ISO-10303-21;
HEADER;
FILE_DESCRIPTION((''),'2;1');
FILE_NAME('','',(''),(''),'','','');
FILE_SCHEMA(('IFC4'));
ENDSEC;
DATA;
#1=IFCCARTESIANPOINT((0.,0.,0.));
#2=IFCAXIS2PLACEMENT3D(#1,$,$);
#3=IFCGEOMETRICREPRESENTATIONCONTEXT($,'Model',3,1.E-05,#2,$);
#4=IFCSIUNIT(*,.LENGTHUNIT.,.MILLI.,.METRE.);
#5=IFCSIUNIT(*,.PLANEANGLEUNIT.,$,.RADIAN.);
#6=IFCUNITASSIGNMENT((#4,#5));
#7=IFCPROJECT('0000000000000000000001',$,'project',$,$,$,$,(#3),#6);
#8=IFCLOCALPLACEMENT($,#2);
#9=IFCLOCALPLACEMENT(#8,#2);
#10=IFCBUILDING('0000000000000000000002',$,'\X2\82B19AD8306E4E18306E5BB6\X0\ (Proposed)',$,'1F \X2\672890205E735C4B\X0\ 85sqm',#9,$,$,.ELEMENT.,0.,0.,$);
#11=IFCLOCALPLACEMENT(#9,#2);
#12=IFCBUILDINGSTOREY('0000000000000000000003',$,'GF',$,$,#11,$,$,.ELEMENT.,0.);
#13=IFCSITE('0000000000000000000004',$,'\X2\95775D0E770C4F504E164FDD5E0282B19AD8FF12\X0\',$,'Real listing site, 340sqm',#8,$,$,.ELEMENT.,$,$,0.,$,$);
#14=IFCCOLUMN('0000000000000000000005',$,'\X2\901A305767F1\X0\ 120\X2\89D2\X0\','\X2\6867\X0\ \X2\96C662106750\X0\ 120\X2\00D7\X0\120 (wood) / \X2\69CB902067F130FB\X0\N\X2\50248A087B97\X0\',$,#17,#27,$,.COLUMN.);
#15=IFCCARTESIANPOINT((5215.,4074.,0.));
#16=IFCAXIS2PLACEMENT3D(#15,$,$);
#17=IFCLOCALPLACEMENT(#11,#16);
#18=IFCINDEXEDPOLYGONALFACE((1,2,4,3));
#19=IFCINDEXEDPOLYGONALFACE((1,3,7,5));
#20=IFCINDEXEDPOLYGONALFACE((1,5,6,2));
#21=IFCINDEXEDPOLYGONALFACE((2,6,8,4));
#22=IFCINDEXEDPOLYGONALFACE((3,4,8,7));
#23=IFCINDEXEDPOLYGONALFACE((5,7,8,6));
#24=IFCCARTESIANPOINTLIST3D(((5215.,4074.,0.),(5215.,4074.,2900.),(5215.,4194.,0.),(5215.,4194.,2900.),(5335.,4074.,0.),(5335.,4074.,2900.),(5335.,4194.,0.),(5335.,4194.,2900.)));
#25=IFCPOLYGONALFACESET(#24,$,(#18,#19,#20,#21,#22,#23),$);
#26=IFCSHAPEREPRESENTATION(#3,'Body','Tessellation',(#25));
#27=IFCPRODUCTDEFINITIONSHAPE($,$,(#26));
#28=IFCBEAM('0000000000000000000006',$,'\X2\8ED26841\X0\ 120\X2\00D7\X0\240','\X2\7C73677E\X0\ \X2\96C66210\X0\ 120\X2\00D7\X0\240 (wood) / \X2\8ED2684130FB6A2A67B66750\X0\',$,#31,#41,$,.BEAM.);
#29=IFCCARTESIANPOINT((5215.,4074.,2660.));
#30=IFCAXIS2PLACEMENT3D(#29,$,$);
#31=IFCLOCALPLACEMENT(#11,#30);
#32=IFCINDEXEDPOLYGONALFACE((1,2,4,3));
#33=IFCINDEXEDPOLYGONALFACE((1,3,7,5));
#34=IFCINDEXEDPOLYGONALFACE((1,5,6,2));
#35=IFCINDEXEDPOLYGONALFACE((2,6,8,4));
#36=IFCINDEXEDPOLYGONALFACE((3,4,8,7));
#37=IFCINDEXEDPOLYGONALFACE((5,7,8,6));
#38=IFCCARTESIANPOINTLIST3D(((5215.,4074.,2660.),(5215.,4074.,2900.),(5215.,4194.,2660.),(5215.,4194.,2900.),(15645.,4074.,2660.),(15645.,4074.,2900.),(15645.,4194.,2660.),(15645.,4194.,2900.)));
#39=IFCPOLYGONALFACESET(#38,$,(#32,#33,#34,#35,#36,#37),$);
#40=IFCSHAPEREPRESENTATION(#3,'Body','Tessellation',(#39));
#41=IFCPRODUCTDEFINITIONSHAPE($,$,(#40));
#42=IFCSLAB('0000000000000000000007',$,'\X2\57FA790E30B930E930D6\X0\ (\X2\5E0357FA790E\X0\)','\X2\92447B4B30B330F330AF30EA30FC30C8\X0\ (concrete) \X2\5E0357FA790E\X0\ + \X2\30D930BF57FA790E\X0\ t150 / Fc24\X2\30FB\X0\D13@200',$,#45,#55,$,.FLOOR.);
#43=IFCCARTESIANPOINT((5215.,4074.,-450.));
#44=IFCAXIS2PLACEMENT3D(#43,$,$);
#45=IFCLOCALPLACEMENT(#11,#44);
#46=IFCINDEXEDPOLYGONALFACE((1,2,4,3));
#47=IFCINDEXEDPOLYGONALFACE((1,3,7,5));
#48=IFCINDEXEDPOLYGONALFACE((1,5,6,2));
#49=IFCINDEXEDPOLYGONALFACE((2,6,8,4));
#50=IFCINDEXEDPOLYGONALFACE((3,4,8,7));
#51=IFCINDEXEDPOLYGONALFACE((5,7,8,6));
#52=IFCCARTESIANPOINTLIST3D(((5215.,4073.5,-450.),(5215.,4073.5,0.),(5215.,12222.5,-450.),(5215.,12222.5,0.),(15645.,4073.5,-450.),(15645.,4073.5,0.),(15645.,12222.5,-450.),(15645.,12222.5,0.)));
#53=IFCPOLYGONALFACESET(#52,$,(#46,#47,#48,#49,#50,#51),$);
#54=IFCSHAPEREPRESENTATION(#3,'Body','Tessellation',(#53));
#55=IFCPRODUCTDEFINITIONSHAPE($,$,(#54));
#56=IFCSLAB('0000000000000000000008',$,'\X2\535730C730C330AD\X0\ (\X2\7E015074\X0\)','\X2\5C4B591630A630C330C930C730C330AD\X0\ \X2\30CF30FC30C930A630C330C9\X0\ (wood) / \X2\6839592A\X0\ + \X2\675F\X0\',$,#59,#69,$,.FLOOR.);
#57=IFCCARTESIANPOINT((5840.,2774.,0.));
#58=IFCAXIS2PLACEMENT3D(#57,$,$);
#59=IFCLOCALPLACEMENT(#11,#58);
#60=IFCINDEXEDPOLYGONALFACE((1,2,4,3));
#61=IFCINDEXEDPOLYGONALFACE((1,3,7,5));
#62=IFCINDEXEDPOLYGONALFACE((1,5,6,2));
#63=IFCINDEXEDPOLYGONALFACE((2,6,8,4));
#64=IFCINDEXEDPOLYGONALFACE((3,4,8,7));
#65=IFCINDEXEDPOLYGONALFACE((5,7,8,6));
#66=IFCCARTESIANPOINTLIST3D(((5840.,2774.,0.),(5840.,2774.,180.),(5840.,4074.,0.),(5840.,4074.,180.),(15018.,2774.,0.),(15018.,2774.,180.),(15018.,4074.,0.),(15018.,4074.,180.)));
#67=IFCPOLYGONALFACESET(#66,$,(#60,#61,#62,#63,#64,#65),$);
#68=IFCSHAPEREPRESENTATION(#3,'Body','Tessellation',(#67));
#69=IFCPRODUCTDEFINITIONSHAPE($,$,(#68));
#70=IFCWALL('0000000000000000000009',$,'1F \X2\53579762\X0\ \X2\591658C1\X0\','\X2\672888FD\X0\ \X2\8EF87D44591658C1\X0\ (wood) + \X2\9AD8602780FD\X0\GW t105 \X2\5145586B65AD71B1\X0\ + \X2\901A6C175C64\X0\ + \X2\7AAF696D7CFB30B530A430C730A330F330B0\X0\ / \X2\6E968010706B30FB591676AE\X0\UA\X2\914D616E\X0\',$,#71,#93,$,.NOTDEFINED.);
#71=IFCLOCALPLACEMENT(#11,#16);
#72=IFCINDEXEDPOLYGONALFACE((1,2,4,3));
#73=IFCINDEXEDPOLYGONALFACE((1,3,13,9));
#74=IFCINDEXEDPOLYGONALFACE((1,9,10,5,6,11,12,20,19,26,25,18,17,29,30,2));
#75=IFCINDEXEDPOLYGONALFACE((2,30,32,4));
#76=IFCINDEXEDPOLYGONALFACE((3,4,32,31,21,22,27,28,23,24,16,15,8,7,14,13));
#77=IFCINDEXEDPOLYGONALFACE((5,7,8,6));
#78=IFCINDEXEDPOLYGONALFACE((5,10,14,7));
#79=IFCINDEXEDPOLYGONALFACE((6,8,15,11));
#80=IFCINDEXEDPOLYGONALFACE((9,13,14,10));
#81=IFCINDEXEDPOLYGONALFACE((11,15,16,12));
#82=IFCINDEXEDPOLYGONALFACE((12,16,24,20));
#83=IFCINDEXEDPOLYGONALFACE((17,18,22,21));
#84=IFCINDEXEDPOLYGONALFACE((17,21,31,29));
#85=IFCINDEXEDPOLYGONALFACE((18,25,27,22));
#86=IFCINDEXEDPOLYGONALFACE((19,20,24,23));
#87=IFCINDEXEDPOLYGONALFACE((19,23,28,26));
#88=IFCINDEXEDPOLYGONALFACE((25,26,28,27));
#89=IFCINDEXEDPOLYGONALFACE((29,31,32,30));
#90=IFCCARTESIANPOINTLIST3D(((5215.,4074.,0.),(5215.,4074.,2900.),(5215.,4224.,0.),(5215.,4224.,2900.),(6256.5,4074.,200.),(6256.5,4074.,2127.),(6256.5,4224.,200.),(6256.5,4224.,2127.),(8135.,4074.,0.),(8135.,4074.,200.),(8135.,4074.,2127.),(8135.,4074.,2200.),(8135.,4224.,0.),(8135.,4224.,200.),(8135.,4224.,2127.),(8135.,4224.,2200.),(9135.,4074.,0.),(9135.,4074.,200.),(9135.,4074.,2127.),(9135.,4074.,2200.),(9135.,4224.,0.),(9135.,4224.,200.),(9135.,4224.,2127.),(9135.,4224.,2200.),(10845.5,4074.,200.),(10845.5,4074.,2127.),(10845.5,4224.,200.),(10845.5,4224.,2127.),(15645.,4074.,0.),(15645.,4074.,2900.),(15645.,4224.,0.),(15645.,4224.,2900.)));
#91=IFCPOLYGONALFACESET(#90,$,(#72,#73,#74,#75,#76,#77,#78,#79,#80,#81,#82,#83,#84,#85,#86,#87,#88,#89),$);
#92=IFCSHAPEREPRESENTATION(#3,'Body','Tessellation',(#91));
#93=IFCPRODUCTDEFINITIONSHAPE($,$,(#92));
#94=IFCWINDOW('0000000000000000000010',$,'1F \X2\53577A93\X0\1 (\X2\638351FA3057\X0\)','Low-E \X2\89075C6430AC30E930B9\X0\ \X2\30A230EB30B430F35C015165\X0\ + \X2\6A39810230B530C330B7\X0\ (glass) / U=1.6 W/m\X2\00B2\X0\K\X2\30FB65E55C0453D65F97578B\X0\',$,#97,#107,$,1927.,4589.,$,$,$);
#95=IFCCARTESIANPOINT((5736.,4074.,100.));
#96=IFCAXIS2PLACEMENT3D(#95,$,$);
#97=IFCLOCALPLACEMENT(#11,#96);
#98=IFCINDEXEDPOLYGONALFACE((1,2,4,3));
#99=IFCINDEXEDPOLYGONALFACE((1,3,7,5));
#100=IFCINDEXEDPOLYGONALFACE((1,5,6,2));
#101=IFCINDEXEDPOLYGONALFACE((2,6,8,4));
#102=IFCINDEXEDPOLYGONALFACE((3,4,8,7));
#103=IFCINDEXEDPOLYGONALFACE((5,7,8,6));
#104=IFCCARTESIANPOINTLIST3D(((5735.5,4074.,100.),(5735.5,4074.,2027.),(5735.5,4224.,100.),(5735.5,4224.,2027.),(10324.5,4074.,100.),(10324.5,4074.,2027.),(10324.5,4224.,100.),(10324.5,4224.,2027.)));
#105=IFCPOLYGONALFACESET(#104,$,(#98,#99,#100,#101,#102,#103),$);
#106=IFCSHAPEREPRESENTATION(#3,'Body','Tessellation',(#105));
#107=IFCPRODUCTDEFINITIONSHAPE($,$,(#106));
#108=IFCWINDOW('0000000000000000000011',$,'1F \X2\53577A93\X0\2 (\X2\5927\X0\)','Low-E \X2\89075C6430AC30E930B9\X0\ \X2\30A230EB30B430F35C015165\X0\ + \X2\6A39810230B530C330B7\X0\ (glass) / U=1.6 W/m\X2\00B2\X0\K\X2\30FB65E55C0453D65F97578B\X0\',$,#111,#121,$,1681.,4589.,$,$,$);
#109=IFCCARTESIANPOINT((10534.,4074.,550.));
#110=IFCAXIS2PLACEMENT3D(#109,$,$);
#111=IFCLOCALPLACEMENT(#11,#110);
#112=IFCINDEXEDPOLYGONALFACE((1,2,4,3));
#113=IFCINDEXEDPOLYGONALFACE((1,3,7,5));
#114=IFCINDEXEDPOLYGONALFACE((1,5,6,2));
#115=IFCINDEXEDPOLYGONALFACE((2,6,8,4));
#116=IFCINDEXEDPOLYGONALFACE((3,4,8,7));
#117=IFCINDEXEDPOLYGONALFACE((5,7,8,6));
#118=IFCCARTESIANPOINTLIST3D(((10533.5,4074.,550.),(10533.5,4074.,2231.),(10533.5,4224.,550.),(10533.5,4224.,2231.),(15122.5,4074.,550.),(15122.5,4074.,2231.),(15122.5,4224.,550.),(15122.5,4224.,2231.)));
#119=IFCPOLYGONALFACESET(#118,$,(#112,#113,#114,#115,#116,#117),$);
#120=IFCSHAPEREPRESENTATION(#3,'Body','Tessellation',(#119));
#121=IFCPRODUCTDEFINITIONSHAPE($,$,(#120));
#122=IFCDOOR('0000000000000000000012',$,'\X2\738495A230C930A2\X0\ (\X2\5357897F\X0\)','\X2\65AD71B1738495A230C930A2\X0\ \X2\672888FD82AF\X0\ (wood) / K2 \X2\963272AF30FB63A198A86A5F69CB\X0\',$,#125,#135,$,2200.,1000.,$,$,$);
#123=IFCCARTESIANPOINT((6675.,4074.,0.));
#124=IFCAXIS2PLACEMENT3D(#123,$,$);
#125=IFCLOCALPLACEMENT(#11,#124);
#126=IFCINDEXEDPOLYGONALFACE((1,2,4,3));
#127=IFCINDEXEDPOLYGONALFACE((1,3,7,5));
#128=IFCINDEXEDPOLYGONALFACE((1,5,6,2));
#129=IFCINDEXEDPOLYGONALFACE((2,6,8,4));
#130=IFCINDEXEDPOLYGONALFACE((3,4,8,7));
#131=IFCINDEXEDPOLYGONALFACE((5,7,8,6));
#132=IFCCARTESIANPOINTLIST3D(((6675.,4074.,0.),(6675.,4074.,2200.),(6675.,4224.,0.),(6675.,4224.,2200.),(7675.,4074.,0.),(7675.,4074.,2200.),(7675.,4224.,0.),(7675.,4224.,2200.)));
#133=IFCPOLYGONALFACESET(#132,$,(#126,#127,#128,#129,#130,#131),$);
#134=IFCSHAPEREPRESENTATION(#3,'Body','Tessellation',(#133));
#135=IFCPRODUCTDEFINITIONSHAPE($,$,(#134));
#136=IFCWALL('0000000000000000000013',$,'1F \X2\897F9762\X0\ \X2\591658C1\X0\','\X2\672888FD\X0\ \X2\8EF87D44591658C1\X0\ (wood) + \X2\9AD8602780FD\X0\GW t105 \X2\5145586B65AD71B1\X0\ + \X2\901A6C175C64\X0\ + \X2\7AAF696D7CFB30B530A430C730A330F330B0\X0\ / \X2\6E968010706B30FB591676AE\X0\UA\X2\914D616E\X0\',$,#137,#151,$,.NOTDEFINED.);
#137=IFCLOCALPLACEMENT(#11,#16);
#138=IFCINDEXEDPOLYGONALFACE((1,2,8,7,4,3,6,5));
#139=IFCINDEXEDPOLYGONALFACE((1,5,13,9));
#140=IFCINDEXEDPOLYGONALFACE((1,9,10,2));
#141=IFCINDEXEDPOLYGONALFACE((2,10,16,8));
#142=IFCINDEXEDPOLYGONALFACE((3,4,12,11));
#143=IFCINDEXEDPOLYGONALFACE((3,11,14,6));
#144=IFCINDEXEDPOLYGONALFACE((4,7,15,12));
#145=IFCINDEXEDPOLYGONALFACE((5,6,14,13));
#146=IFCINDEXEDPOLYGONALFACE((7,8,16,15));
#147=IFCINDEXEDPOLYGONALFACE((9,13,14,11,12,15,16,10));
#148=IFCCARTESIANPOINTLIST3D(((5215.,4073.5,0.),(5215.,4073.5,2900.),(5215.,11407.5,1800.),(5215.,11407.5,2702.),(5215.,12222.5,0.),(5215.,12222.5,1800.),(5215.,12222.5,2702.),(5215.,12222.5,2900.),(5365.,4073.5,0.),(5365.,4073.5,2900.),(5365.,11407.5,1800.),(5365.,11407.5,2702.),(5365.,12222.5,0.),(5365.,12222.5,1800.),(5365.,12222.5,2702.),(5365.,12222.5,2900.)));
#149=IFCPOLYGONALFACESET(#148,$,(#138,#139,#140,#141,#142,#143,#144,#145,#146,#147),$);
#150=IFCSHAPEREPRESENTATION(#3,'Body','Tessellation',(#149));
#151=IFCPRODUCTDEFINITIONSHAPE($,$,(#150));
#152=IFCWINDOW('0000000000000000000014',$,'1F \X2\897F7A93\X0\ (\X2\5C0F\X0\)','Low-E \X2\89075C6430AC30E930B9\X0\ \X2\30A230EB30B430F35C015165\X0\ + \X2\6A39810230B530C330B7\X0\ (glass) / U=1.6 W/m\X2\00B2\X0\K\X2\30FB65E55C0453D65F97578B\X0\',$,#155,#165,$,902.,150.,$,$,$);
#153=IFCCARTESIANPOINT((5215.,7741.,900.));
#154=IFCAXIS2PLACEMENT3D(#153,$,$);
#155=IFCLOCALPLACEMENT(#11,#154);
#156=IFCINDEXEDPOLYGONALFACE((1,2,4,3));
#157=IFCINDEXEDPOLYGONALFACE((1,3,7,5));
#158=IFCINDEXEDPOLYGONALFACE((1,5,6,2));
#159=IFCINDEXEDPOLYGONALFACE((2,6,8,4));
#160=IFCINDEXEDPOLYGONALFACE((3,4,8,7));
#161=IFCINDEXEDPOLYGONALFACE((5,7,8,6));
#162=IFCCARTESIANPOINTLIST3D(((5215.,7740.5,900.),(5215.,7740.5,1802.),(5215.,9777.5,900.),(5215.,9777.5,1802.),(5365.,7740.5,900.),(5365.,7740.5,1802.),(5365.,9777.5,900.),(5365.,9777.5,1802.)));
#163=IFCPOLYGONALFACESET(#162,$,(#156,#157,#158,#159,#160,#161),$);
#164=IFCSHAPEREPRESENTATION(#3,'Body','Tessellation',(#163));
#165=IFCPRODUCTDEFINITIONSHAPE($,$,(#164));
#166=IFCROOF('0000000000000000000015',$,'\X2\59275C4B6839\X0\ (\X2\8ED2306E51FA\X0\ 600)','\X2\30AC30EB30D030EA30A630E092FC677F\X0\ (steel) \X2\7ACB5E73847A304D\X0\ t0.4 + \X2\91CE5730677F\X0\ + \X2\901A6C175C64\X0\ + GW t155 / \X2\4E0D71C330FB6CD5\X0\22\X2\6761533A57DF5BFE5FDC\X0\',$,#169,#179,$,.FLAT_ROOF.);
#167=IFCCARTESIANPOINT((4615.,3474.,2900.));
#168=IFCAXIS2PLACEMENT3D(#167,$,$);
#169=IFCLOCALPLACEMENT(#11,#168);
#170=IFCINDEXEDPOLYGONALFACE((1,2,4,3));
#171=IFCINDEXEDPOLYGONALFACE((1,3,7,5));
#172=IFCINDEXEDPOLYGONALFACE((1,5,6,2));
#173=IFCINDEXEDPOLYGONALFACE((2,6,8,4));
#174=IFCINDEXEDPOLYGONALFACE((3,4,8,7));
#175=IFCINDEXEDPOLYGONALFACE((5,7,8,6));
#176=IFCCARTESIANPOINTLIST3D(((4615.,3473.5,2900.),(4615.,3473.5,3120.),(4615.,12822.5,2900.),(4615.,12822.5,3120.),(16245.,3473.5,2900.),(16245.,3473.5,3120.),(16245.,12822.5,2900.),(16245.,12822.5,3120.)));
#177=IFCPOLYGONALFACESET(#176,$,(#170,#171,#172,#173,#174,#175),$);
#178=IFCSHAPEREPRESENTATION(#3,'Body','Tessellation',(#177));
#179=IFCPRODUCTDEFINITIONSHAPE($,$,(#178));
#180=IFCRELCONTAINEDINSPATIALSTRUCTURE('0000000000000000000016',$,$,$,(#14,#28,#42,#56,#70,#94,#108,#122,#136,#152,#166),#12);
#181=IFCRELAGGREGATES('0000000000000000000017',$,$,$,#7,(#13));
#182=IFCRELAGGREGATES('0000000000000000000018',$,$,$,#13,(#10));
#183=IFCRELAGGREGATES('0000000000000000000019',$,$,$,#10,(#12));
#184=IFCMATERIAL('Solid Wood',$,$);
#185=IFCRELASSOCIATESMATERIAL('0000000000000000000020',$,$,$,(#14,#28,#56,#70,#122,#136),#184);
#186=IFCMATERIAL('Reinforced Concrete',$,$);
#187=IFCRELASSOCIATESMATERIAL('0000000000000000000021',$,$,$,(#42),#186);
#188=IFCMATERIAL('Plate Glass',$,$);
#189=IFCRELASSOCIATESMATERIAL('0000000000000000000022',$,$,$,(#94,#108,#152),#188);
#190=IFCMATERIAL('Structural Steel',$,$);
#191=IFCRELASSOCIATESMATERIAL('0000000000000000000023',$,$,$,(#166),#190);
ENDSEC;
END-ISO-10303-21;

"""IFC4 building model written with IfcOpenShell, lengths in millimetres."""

from ifc_helpers import new_model, si_unit, frame, frame_2d, origin, place, context, project, spatial, rectangle, extrude, material, element, fill, save


model = new_model("IFC4")

# Units and contexts
model_context = context("Model", 3, precision=1e-05, world=origin())
ifc_project = project(units=[si_unit("LENGTHUNIT", "METRE", prefix="MILLI"), si_unit("PLANEANGLEUNIT", "RADIAN")], contexts=[model_context])

# Site, building, storey
site_placement = place(None, origin())
site = spatial("IfcSite", under=ifc_project, at=site_placement, Name="長崎県佐世保市花高２", ObjectType="Real listing site, 340sqm", CompositionType="ELEMENT", RefElevation=0.0)
building_placement = place(site_placement, origin())
building = spatial("IfcBuilding", under=site, at=building_placement, Name="花高の丘の家 (Proposed)", ObjectType="1F 木造平屋 85sqm", CompositionType="ELEMENT", ElevationOfRefHeight=0.0, ElevationOfTerrain=0.0)
storey_placement = place(building_placement, origin())
storey = spatial("IfcBuildingStorey", under=building, at=storey_placement, Name="GF", CompositionType="ELEMENT", Elevation=0.0)

# Column
ifc_material_1 = material(Name="Solid Wood")
column_1_placement = place(storey_placement, frame((5215.0, 4074.0, 0.0)))
element("IfcColumn", 1, at=column_1_placement, inside=storey, material=ifc_material_1, Name="通し柱 120角", Description="桧 集成材 120×120 (wood) / 構造柱・N値計算", PredefinedType="COLUMN", context=model_context, shape_type="SweptSolid", body=[
    extrude(rectangle(XDim=120.0, YDim=120.0, at=frame_2d((60.0, 60.0))), frame((5215.0, 4074.0, 0.0)), (0.0, 0.0, 1.0), 2900.0),
])

# Beam
beam_1_placement = place(storey_placement, frame((5215.0, 4074.0, 2660.0)))
element("IfcBeam", 2, at=beam_1_placement, inside=storey, material=ifc_material_1, Name="軒桁 120×240", Description="米松 集成 120×240 (wood) / 軒桁・横架材", PredefinedType="BEAM", context=model_context, shape_type="SweptSolid", body=[
    extrude(rectangle(XDim=10430.0, YDim=120.0, at=frame_2d((5215.0, 60.0))), frame((5215.0, 4074.0, 2660.0)), (0.0, 0.0, 1.0), 240.0),
])

# Slabs
ifc_material_2 = material(Name="Reinforced Concrete")
slab_1_placement = place(storey_placement, frame((5215.0, 4074.0, -450.0)))
element("IfcSlab", 3, at=slab_1_placement, inside=storey, material=ifc_material_2, Name="基礎スラブ (布基礎)", Description="鉄筋コンクリート (concrete) 布基礎 + ベタ基礎 t150 / Fc24・D13@200", PredefinedType="FLOOR", context=model_context, shape_type="SweptSolid", body=[
    extrude(rectangle(XDim=10430.0, YDim=8149.0, at=frame_2d((5215.0, 4074.0))), frame((5215.0, 4074.0, -450.0)), (0.0, 0.0, 1.0), 450.0),
])
slab_2_placement = place(storey_placement, frame((5840.0, 2774.0, 0.0)))
element("IfcSlab", 4, at=slab_2_placement, inside=storey, material=ifc_material_1, Name="南デッキ (縁側)", Description="屋外ウッドデッキ ハードウッド (wood) / 根太 + 束", PredefinedType="FLOOR", context=model_context, shape_type="SweptSolid", body=[
    extrude(rectangle(XDim=9178.0, YDim=1300.0, at=frame_2d((4589.0, 650.0))), frame((5840.0, 2774.0, 0.0)), (0.0, 0.0, 1.0), 180.0),
])

# Wall, openings, windows, door
wall_1_placement = place(storey_placement, frame((5215.0, 4074.0, 0.0)))
wall_1 = element("IfcWall", 5, at=wall_1_placement, inside=storey, material=ifc_material_1, Name="1F 南面 外壁", Description="木製 軸組外壁 (wood) + 高性能GW t105 充填断熱 + 通気層 + 窯業系サイディング / 準耐火・外皮UA配慮", PredefinedType="NOTDEFINED", context=model_context, shape_type="SweptSolid", body=[
    extrude(rectangle(XDim=10430.0, YDim=150.0, at=frame_2d((5215.0, 75.0))), frame((5215.0, 4074.0, 0.0)), (0.0, 0.0, 1.0), 2900.0),
])
opening_1_placement = place(storey_placement, frame((5736.0, 4074.0, 100.0)))
opening_1 = element("IfcOpeningElement", 6, at=opening_1_placement, cuts=wall_1, PredefinedType="NOTDEFINED", context=model_context, shape_type="SweptSolid", body=[
    extrude(rectangle(XDim=4589.0, YDim=150.0, at=frame_2d((2294.0, 75.0))), frame((5736.0, 4074.0, 100.0)), (0.0, 0.0, 1.0), 1927.0),
])
opening_2_placement = place(storey_placement, frame((10534.0, 4074.0, 550.0)))
opening_2 = element("IfcOpeningElement", 7, at=opening_2_placement, cuts=wall_1, PredefinedType="NOTDEFINED", context=model_context, shape_type="SweptSolid", body=[
    extrude(rectangle(XDim=4589.0, YDim=150.0, at=frame_2d((2294.0, 75.0))), frame((10534.0, 4074.0, 550.0)), (0.0, 0.0, 1.0), 1681.0),
])
opening_3_placement = place(storey_placement, frame((6675.0, 4074.0, 0.0)))
opening_3 = element("IfcOpeningElement", 8, at=opening_3_placement, cuts=wall_1, PredefinedType="NOTDEFINED", context=model_context, shape_type="SweptSolid", body=[
    extrude(rectangle(XDim=1000.0, YDim=150.0, at=frame_2d((500.0, 75.0))), frame((6675.0, 4074.0, 0.0)), (0.0, 0.0, 1.0), 2200.0),
])
ifc_material_3 = material(Name="Plate Glass")
window_1_placement = place(storey_placement, frame((5736.0, 4074.0, 100.0)))
window_1 = element("IfcWindow", 9, at=window_1_placement, inside=storey, material=ifc_material_3, Name="1F 南窓1 (掃出し)", Description="Low-E 複層ガラス アルゴン封入 + 樹脂サッシ (glass) / U=1.6 W/m²K・日射取得型", OverallHeight=1927.0, OverallWidth=4589.0, context=model_context, shape_type="SweptSolid", body=[
    extrude(rectangle(XDim=4589.0, YDim=150.0, at=frame_2d((2294.0, 75.0))), frame((5736.0, 4074.0, 100.0)), (0.0, 0.0, 1.0), 1927.0),
])
fill(opening_1, window_1)
window_2_placement = place(storey_placement, frame((10534.0, 4074.0, 550.0)))
window_2 = element("IfcWindow", 10, at=window_2_placement, inside=storey, material=ifc_material_3, Name="1F 南窓2 (大)", Description="Low-E 複層ガラス アルゴン封入 + 樹脂サッシ (glass) / U=1.6 W/m²K・日射取得型", OverallHeight=1681.0, OverallWidth=4589.0, context=model_context, shape_type="SweptSolid", body=[
    extrude(rectangle(XDim=4589.0, YDim=150.0, at=frame_2d((2294.0, 75.0))), frame((10534.0, 4074.0, 550.0)), (0.0, 0.0, 1.0), 1681.0),
])
fill(opening_2, window_2)
door_placement = place(storey_placement, frame((6675.0, 4074.0, 0.0)))
door = element("IfcDoor", 11, at=door_placement, inside=storey, material=ifc_material_1, Name="玄関ドア (南西)", Description="断熱玄関ドア 木製芯 (wood) / K2 防犯・採風機構", OverallHeight=2200.0, OverallWidth=1000.0, context=model_context, shape_type="SweptSolid", body=[
    extrude(rectangle(XDim=1000.0, YDim=150.0, at=frame_2d((500.0, 75.0))), frame((6675.0, 4074.0, 0.0)), (0.0, 0.0, 1.0), 2200.0),
])
fill(opening_3, door)

# Wall, opening, window
wall_2_placement = place(storey_placement, frame((5215.0, 4074.0, 0.0)))
wall_2 = element("IfcWall", 12, at=wall_2_placement, inside=storey, material=ifc_material_1, Name="1F 西面 外壁", Description="木製 軸組外壁 (wood) + 高性能GW t105 充填断熱 + 通気層 + 窯業系サイディング / 準耐火・外皮UA配慮", PredefinedType="NOTDEFINED", context=model_context, shape_type="SweptSolid", body=[
    extrude(rectangle(XDim=150.0, YDim=8149.0, at=frame_2d((75.0, 4074.0))), frame((5215.0, 4074.0, 0.0)), (0.0, 0.0, 1.0), 2900.0),
])
opening_4_placement = place(storey_placement, frame((5215.0, 7741.0, 900.0)))
opening_4 = element("IfcOpeningElement", 13, at=opening_4_placement, cuts=wall_2, PredefinedType="NOTDEFINED", context=model_context, shape_type="SweptSolid", body=[
    extrude(rectangle(XDim=150.0, YDim=2037.0, at=frame_2d((75.0, 1018.0))), frame((5215.0, 7741.0, 900.0)), (0.0, 0.0, 1.0), 902.0),
])
window_3_placement = place(storey_placement, frame((5215.0, 7741.0, 900.0)))
window_3 = element("IfcWindow", 14, at=window_3_placement, inside=storey, material=ifc_material_3, Name="1F 西窓 (小)", Description="Low-E 複層ガラス アルゴン封入 + 樹脂サッシ (glass) / U=1.6 W/m²K・日射取得型", OverallHeight=902.0, OverallWidth=150.0, context=model_context, shape_type="SweptSolid", body=[
    extrude(rectangle(XDim=150.0, YDim=2037.0, at=frame_2d((75.0, 1018.0))), frame((5215.0, 7741.0, 900.0)), (0.0, 0.0, 1.0), 902.0),
])
fill(opening_4, window_3)

# Roof
ifc_material_4 = material(Name="Structural Steel")
roof_placement = place(storey_placement, frame((4615.0, 3474.0, 2900.0)))
element("IfcRoof", 15, at=roof_placement, inside=storey, material=ifc_material_4, Name="大屋根 (軒の出 600)", Description="ガルバリウム鋼板 (steel) 立平葺き t0.4 + 野地板 + 通気層 + GW t155 / 不燃・法22条区域対応", PredefinedType="FLAT_ROOF", context=model_context, shape_type="SweptSolid", body=[
    extrude(rectangle(XDim=11630.0, YDim=9349.0, at=frame_2d((5815.0, 4674.0))), frame((4615.0, 3474.0, 2900.0)), (0.0, 0.0, 1.0), 220.0),
])

save(model, "model.ifc")
